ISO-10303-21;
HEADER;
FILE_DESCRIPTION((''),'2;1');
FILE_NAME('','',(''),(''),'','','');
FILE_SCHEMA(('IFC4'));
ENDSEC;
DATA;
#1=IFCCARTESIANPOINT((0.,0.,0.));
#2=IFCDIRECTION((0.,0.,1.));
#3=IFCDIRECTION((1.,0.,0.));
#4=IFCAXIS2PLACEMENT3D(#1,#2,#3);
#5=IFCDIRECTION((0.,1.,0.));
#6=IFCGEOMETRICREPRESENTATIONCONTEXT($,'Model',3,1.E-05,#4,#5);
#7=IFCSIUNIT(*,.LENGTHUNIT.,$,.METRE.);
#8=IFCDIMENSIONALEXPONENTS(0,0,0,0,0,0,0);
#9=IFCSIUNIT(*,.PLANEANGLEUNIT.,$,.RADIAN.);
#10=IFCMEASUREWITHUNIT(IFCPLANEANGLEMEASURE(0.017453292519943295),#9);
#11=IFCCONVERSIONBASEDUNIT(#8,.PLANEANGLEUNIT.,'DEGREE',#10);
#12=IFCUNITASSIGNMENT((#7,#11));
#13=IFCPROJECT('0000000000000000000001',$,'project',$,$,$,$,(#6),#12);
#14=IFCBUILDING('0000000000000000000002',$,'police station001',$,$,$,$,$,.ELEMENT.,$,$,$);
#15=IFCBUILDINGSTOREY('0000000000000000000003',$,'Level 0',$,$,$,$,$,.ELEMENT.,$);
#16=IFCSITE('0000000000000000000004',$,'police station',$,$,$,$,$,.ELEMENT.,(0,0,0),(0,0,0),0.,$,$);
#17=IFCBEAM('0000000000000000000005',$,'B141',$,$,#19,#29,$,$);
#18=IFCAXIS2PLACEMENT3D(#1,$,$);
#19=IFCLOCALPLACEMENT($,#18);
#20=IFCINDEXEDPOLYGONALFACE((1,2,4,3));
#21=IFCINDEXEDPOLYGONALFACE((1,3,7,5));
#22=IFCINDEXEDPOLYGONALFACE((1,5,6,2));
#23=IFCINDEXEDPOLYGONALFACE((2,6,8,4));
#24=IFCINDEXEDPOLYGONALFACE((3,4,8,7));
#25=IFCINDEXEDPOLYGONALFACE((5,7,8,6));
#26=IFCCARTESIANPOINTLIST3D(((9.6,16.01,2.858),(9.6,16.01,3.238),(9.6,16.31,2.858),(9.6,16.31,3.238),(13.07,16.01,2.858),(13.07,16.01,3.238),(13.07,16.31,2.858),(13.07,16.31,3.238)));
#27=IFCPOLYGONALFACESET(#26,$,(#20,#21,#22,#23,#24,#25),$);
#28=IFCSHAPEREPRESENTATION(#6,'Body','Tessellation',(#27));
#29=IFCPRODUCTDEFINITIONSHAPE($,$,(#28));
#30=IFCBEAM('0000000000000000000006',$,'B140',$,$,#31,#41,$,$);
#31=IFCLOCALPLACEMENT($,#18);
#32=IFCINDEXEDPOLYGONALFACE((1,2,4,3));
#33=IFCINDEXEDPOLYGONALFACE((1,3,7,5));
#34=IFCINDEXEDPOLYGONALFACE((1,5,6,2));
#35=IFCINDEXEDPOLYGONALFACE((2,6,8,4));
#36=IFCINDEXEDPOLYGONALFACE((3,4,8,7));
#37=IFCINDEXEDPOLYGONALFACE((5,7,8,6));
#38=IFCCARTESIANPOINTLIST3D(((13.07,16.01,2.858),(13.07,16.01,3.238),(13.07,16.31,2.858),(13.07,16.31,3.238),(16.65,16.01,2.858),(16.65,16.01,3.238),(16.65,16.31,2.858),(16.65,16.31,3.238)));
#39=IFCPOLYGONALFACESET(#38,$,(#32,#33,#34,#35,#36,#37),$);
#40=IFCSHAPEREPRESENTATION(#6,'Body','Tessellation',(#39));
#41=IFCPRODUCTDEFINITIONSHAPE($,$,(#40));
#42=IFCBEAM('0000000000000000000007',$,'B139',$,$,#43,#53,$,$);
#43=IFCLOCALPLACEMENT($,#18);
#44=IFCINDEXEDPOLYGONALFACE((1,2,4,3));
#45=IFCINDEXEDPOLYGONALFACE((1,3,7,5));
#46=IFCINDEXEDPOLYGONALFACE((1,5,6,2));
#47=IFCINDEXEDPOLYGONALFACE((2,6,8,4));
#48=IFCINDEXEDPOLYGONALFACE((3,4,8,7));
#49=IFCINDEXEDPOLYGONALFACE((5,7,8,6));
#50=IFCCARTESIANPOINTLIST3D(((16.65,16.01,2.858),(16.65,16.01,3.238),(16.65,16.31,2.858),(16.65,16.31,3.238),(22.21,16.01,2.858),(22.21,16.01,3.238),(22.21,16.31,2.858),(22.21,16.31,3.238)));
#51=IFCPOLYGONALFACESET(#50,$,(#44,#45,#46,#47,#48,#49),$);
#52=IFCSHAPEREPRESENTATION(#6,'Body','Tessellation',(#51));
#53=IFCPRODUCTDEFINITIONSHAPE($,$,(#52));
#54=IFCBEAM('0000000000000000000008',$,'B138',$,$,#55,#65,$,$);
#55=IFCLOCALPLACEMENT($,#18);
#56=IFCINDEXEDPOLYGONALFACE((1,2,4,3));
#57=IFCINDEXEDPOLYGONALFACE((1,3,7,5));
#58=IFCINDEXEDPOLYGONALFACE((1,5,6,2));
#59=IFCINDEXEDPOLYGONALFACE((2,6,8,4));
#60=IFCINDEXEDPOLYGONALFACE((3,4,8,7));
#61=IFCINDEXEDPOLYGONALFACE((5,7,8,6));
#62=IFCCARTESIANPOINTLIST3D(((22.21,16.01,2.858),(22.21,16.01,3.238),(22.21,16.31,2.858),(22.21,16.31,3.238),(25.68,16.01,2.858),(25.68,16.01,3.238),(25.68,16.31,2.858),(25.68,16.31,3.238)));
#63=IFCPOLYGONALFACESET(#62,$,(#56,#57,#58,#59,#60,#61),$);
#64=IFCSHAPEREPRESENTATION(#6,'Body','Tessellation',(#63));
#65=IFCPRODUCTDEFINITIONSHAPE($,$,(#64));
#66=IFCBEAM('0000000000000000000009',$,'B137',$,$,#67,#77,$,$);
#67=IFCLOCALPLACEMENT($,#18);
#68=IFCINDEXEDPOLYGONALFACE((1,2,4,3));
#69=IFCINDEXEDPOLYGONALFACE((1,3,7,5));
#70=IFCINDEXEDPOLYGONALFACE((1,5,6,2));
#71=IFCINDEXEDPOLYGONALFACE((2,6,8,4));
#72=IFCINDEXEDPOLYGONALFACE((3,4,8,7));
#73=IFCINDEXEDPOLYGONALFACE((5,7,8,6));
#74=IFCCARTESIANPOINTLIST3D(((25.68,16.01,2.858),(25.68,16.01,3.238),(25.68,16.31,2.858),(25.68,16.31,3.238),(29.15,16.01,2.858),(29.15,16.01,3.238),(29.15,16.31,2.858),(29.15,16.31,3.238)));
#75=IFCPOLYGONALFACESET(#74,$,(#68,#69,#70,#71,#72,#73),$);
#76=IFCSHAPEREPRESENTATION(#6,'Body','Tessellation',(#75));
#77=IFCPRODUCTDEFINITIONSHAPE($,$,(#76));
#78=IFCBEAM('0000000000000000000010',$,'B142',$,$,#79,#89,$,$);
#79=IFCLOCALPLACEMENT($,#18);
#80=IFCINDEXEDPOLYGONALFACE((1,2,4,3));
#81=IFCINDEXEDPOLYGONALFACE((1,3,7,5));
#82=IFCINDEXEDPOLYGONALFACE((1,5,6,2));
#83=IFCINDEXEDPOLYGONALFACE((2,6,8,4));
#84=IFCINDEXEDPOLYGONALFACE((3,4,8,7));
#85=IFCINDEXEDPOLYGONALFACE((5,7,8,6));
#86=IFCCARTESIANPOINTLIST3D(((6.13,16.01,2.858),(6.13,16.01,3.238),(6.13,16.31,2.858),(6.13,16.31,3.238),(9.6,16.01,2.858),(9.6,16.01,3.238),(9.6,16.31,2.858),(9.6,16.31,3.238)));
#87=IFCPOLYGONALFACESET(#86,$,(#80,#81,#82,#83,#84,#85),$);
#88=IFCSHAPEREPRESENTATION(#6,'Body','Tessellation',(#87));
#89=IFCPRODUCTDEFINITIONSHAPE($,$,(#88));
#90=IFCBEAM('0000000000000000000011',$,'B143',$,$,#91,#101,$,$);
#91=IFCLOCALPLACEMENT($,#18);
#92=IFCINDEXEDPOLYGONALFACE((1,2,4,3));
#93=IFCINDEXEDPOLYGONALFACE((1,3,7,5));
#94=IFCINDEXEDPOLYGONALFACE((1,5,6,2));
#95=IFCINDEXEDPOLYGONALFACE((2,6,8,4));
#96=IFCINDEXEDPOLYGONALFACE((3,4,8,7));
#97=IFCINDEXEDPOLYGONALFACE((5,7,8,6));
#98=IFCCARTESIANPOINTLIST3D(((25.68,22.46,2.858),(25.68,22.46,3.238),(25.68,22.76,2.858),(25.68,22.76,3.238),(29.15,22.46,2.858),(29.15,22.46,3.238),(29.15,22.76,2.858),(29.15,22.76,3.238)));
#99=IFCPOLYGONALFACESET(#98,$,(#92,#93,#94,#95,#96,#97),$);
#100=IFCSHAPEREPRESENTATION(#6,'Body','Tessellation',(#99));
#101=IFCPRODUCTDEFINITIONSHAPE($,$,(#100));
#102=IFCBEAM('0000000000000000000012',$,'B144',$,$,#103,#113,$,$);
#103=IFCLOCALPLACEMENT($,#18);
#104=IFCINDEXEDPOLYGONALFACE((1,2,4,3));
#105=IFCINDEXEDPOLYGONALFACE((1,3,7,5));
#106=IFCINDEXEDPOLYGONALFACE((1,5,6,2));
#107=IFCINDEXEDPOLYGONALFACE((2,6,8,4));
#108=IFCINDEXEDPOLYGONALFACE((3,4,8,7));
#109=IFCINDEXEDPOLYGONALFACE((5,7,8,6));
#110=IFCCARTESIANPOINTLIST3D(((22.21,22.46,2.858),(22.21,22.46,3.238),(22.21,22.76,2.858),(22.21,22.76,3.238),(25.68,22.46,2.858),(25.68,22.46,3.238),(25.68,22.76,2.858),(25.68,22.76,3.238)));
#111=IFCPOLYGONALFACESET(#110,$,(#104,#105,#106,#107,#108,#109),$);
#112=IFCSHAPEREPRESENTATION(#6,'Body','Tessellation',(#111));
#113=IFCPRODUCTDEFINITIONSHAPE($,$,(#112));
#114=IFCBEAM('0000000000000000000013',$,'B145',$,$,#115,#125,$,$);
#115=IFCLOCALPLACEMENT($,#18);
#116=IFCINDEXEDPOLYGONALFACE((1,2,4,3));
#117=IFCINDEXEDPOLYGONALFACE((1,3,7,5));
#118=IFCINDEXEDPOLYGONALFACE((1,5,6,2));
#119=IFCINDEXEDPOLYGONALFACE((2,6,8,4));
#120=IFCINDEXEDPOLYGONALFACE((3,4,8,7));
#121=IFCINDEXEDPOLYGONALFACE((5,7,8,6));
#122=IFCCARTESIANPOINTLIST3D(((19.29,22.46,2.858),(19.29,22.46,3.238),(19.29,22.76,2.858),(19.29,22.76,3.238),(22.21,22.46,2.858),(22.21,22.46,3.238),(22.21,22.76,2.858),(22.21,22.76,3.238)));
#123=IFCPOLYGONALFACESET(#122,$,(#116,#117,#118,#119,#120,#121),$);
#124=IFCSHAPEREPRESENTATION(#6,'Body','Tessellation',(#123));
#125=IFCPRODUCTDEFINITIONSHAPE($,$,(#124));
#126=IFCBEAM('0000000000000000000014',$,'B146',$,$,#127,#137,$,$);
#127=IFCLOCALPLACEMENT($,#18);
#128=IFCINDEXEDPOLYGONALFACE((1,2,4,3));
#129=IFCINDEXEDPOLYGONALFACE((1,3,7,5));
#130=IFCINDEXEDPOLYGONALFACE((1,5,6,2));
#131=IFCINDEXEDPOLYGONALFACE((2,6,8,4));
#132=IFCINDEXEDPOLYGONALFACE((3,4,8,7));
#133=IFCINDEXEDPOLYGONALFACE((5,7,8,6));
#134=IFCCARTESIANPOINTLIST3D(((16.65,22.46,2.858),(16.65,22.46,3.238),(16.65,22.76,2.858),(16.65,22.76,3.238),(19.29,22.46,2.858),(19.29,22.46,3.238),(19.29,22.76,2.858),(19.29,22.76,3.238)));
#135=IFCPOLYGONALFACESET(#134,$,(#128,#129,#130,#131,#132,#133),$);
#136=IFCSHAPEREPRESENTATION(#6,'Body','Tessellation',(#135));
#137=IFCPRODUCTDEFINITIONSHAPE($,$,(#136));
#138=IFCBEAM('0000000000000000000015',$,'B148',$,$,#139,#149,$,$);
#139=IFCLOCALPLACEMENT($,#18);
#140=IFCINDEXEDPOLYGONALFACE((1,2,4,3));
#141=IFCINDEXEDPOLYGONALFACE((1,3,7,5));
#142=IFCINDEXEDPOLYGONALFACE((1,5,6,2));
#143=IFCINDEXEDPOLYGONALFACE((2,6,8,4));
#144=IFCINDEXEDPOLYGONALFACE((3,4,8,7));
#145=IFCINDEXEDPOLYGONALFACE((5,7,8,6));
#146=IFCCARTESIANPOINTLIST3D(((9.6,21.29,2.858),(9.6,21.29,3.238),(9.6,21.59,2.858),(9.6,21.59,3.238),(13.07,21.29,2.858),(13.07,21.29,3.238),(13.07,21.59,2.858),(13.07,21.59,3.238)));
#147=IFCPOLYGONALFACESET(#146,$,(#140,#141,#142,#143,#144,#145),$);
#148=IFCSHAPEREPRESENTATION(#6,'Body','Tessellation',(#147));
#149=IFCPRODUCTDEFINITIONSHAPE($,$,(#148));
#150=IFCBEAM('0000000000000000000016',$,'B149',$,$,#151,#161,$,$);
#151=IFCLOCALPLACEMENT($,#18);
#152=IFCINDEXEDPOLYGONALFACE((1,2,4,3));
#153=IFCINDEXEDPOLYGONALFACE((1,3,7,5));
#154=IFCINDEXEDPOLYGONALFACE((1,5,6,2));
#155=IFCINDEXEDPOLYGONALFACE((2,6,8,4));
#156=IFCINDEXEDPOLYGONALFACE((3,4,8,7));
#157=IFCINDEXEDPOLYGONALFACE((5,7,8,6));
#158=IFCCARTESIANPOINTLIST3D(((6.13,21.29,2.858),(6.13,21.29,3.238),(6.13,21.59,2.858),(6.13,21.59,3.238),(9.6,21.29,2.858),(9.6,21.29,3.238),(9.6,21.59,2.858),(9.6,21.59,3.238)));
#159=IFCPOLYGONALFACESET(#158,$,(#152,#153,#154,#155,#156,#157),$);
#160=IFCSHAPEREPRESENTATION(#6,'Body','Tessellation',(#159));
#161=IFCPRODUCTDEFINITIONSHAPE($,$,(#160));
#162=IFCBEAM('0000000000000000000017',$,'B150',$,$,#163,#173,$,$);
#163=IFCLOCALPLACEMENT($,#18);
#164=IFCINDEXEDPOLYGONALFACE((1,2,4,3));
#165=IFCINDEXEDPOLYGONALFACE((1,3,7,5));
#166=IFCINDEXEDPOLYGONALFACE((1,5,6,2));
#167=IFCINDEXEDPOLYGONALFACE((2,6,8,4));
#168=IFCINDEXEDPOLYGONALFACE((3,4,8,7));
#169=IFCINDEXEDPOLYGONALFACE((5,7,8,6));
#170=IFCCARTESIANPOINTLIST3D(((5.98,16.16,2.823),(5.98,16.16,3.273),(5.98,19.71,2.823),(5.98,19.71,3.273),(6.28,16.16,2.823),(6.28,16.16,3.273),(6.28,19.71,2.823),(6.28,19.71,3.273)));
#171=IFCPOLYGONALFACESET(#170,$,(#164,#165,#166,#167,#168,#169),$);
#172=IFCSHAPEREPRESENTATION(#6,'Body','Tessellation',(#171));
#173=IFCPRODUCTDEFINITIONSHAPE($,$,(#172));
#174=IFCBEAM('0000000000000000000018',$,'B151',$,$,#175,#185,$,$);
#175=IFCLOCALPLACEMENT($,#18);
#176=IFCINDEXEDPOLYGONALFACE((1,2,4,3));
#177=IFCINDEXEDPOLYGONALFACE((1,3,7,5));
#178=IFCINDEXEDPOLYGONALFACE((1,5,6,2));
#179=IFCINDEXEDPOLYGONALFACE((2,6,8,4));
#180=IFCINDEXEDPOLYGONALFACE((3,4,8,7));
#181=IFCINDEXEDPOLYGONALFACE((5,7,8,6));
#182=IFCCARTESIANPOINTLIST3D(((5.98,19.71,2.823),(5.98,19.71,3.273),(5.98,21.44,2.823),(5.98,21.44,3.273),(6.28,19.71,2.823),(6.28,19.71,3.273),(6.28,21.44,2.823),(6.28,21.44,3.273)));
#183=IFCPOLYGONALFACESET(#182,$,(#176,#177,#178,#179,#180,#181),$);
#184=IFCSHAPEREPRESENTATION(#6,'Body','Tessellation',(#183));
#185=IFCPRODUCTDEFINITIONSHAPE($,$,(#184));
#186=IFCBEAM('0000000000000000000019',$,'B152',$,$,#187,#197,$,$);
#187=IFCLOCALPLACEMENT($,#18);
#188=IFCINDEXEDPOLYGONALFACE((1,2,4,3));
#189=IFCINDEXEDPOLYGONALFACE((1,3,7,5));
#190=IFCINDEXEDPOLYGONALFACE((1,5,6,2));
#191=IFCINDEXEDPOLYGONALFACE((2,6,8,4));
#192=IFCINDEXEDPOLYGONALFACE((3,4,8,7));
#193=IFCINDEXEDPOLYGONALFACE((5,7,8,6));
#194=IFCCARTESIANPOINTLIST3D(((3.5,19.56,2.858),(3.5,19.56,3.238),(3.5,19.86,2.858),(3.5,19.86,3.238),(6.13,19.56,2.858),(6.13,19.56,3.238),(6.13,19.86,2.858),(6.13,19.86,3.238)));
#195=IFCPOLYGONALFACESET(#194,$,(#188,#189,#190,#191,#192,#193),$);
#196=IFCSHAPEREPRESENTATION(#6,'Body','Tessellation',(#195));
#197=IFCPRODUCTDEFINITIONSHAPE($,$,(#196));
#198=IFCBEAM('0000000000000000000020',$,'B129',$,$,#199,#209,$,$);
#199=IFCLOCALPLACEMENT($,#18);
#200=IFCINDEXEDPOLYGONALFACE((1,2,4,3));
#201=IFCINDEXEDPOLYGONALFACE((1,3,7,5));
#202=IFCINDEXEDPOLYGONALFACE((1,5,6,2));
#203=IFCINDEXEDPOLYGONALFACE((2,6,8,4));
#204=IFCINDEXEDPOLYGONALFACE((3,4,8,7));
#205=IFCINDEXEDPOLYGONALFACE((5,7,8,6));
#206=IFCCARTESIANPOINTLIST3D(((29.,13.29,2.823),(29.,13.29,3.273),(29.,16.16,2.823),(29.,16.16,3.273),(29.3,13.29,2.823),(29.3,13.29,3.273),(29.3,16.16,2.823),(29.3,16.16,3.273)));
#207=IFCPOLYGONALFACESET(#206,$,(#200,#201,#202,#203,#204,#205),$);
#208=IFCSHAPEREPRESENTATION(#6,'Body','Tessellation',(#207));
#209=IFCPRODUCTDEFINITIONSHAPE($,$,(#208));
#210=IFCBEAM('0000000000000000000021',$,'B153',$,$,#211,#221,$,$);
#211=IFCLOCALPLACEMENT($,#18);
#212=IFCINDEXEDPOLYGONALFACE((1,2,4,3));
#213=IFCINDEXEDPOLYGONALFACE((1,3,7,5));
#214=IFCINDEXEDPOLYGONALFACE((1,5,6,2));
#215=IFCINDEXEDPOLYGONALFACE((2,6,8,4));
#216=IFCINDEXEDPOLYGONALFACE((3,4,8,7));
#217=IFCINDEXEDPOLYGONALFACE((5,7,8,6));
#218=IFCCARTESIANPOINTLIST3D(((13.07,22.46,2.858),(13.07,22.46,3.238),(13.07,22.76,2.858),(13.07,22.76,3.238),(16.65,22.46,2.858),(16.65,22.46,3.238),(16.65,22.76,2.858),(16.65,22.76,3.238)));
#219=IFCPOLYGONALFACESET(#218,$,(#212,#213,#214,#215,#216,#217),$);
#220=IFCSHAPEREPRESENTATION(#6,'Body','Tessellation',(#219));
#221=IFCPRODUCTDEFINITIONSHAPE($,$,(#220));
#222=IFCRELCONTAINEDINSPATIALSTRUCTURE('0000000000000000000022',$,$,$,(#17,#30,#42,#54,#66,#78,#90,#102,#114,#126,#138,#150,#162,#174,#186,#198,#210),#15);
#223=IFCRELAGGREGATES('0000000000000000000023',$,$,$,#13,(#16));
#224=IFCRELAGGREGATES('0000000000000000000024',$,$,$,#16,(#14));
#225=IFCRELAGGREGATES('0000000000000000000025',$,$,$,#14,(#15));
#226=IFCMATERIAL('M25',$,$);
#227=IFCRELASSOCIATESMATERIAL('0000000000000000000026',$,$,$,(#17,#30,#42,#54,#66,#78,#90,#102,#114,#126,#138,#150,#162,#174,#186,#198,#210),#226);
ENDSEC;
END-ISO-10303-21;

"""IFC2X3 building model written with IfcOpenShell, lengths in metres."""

from ifc_helpers import new_model, entity, si_unit, converted_unit, direction, frame, frame_2d, origin_with_axes, place, context, project, spatial, rectangle, extrude, material, element, save


model = new_model("IFC2X3")

# Units and contexts
model_context = context("Model", 3, precision=1e-05, world=origin_with_axes(), true_north=direction((0.0, 1.0, 0.0)))
ifc_project = project(units=[si_unit("LENGTHUNIT", "METRE"), converted_unit("PLANEANGLEUNIT", "DEGREE", entity("IfcPlaneAngleMeasure", 0.017453292519943295), si_unit("PLANEANGLEUNIT", "RADIAN"), dimensions=[0, 0, 0, 0, 0, 0, 0])], contexts=[model_context])

# Site, building, storey
site = spatial("IfcSite", under=ifc_project, Name="police station", CompositionType="ELEMENT", RefLatitude=(0, 0, 0), RefLongitude=(0, 0, 0), RefElevation=0.0)
building = spatial("IfcBuilding", under=site, Name="police station001", CompositionType="ELEMENT")
storey = spatial("IfcBuildingStorey", under=building, Name="Level 0", CompositionType="ELEMENT")

# Beams
ifc_material = material(Name="M25")
placement = place(None, origin_with_axes())
element("IfcBeam", 1, at=placement, inside=storey, material=ifc_material, Name="B141", context=model_context, shape_type="SweptSolid", body=[
    extrude(rectangle(XDim=0.3, YDim=0.38, at=frame_2d((0.0, 0.0), x_axis=(0.0, 1.0, 0.0))), frame((13.07, 16.16, 3.048), z_axis=(-1.0, 0.0, 0.0), x_axis=(0.0, 0.0, -1.0)), (0.0, 0.0, 1.0), 3.47),
])
element("IfcBeam", 2, at=placement, inside=storey, material=ifc_material, Name="B140", context=model_context, shape_type="SweptSolid", body=[
    extrude(rectangle(XDim=0.3, YDim=0.38, at=frame_2d((0.0, 0.0), x_axis=(0.0, 1.0, 0.0))), frame((16.65, 16.16, 3.048), z_axis=(-1.0, 0.0, 0.0), x_axis=(0.0, 0.0, -1.0)), (0.0, 0.0, 1.0), 3.58),
])
element("IfcBeam", 3, at=placement, inside=storey, material=ifc_material, Name="B139", context=model_context, shape_type="SweptSolid", body=[
    extrude(rectangle(XDim=0.3, YDim=0.38, at=frame_2d((0.0, 0.0), x_axis=(0.0, 1.0, 0.0))), frame((22.21, 16.16, 3.048), z_axis=(-1.0, 0.0, 0.0), x_axis=(0.0, 0.0, -1.0)), (0.0, 0.0, 1.0), 5.56),
])
element("IfcBeam", 4, at=placement, inside=storey, material=ifc_material, Name="B138", context=model_context, shape_type="SweptSolid", body=[
    extrude(rectangle(XDim=0.3, YDim=0.38, at=frame_2d((0.0, 0.0), x_axis=(0.0, 1.0, 0.0))), frame((22.21, 16.16, 3.048), z_axis=(1.0, 0.0, 0.0), x_axis=(0.0, 0.0, -1.0)), (0.0, 0.0, 1.0), 3.47),
])
element("IfcBeam", 5, at=placement, inside=storey, material=ifc_material, Name="B137", context=model_context, shape_type="SweptSolid", body=[
    extrude(rectangle(XDim=0.3, YDim=0.38, at=frame_2d((0.0, 0.0), x_axis=(0.0, 1.0, 0.0))), frame((25.68, 16.16, 3.048), z_axis=(1.0, 0.0, 0.0), x_axis=(0.0, 0.0, -1.0)), (0.0, 0.0, 1.0), 3.47),
])
element("IfcBeam", 6, at=placement, inside=storey, material=ifc_material, Name="B142", context=model_context, shape_type="SweptSolid", body=[
    extrude(rectangle(XDim=0.3, YDim=0.38, at=frame_2d((0.0, 0.0), x_axis=(0.0, 1.0, 0.0))), frame((9.6, 16.16, 3.048), z_axis=(-1.0, 0.0, 0.0), x_axis=(0.0, 0.0, -1.0)), (0.0, 0.0, 1.0), 3.47),
])
element("IfcBeam", 7, at=placement, inside=storey, material=ifc_material, Name="B143", context=model_context, shape_type="SweptSolid", body=[
    extrude(rectangle(XDim=0.3, YDim=0.38, at=frame_2d((0.0, 0.0), x_axis=(0.0, 1.0, 0.0))), frame((29.15, 22.61, 3.048), z_axis=(-1.0, 0.0, 0.0), x_axis=(0.0, 0.0, -1.0)), (0.0, 0.0, 1.0), 3.47),
])
element("IfcBeam", 8, at=placement, inside=storey, material=ifc_material, Name="B144", context=model_context, shape_type="SweptSolid", body=[
    extrude(rectangle(XDim=0.3, YDim=0.38, at=frame_2d((0.0, 0.0), x_axis=(0.0, 1.0, 0.0))), frame((25.68, 22.61, 3.048), z_axis=(-1.0, 0.0, 0.0), x_axis=(0.0, 0.0, -1.0)), (0.0, 0.0, 1.0), 3.47),
])
element("IfcBeam", 9, at=placement, inside=storey, material=ifc_material, Name="B145", context=model_context, shape_type="SweptSolid", body=[
    extrude(rectangle(XDim=0.3, YDim=0.38, at=frame_2d((0.0, 0.0), x_axis=(0.0, 1.0, 0.0))), frame((22.21, 22.61, 3.048), z_axis=(-1.0, 0.0, 0.0), x_axis=(0.0, 0.0, -1.0)), (0.0, 0.0, 1.0), 2.92),
])
element("IfcBeam", 10, at=placement, inside=storey, material=ifc_material, Name="B146", context=model_context, shape_type="SweptSolid", body=[
    extrude(rectangle(XDim=0.3, YDim=0.38, at=frame_2d((0.0, 0.0), x_axis=(0.0, 1.0, 0.0))), frame((19.29, 22.61, 3.048), z_axis=(-1.0, 0.0, 0.0), x_axis=(0.0, 0.0, -1.0)), (0.0, 0.0, 1.0), 2.64),
])
element("IfcBeam", 11, at=placement, inside=storey, material=ifc_material, Name="B148", context=model_context, shape_type="SweptSolid", body=[
    extrude(rectangle(XDim=0.3, YDim=0.38, at=frame_2d((0.0, 0.0), x_axis=(0.0, 1.0, 0.0))), frame((13.07, 21.44, 3.048), z_axis=(-1.0, 0.0, 0.0), x_axis=(0.0, 0.0, -1.0)), (0.0, 0.0, 1.0), 3.47),
])
element("IfcBeam", 12, at=placement, inside=storey, material=ifc_material, Name="B149", context=model_context, shape_type="SweptSolid", body=[
    extrude(rectangle(XDim=0.3, YDim=0.38, at=frame_2d((0.0, 0.0), x_axis=(0.0, 1.0, 0.0))), frame((9.6, 21.44, 3.048), z_axis=(-1.0, 0.0, 0.0), x_axis=(0.0, 0.0, -1.0)), (0.0, 0.0, 1.0), 3.47),
])
element("IfcBeam", 13, at=placement, inside=storey, material=ifc_material, Name="B150", context=model_context, shape_type="SweptSolid", body=[
    extrude(rectangle(XDim=0.3, YDim=0.45, at=frame_2d((0.0, 0.0), x_axis=(0.0, 1.0, 0.0))), frame((6.13, 16.16, 3.048), z_axis=(0.0, 1.0, 0.0), x_axis=(0.0, 0.0, -1.0)), (0.0, 0.0, 1.0), 3.55),
])
element("IfcBeam", 14, at=placement, inside=storey, material=ifc_material, Name="B151", context=model_context, shape_type="SweptSolid", body=[
    extrude(rectangle(XDim=0.3, YDim=0.45, at=frame_2d((0.0, 0.0), x_axis=(0.0, 1.0, 0.0))), frame((6.13, 19.71, 3.048), z_axis=(0.0, 1.0, 0.0), x_axis=(0.0, 0.0, -1.0)), (0.0, 0.0, 1.0), 1.73),
])
element("IfcBeam", 15, at=placement, inside=storey, material=ifc_material, Name="B152", context=model_context, shape_type="SweptSolid", body=[
    extrude(rectangle(XDim=0.3, YDim=0.38, at=frame_2d((0.0, 0.0), x_axis=(0.0, 1.0, 0.0))), frame((3.5, 19.71, 3.048), z_axis=(1.0, 0.0, 0.0), x_axis=(0.0, 0.0, -1.0)), (0.0, 0.0, 1.0), 2.63),
])
element("IfcBeam", 16, at=placement, inside=storey, material=ifc_material, Name="B129", context=model_context, shape_type="SweptSolid", body=[
    extrude(rectangle(XDim=0.3, YDim=0.45, at=frame_2d((0.0, 0.0), x_axis=(0.0, 1.0, 0.0))), frame((29.15, 13.29, 3.048), z_axis=(0.0, 1.0, 0.0), x_axis=(0.0, 0.0, -1.0)), (0.0, 0.0, 1.0), 2.87),
])
element("IfcBeam", 17, at=placement, inside=storey, material=ifc_material, Name="B153", context=model_context, shape_type="SweptSolid", body=[
    extrude(rectangle(XDim=0.3, YDim=0.38, at=frame_2d((0.0, 0.0), x_axis=(0.0, 1.0, 0.0))), frame((13.07, 22.61, 3.048), z_axis=(1.0, 0.0, 0.0), x_axis=(0.0, 0.0, -1.0)), (0.0, 0.0, 1.0), 3.58),
])

save(model, "model.ifc")
